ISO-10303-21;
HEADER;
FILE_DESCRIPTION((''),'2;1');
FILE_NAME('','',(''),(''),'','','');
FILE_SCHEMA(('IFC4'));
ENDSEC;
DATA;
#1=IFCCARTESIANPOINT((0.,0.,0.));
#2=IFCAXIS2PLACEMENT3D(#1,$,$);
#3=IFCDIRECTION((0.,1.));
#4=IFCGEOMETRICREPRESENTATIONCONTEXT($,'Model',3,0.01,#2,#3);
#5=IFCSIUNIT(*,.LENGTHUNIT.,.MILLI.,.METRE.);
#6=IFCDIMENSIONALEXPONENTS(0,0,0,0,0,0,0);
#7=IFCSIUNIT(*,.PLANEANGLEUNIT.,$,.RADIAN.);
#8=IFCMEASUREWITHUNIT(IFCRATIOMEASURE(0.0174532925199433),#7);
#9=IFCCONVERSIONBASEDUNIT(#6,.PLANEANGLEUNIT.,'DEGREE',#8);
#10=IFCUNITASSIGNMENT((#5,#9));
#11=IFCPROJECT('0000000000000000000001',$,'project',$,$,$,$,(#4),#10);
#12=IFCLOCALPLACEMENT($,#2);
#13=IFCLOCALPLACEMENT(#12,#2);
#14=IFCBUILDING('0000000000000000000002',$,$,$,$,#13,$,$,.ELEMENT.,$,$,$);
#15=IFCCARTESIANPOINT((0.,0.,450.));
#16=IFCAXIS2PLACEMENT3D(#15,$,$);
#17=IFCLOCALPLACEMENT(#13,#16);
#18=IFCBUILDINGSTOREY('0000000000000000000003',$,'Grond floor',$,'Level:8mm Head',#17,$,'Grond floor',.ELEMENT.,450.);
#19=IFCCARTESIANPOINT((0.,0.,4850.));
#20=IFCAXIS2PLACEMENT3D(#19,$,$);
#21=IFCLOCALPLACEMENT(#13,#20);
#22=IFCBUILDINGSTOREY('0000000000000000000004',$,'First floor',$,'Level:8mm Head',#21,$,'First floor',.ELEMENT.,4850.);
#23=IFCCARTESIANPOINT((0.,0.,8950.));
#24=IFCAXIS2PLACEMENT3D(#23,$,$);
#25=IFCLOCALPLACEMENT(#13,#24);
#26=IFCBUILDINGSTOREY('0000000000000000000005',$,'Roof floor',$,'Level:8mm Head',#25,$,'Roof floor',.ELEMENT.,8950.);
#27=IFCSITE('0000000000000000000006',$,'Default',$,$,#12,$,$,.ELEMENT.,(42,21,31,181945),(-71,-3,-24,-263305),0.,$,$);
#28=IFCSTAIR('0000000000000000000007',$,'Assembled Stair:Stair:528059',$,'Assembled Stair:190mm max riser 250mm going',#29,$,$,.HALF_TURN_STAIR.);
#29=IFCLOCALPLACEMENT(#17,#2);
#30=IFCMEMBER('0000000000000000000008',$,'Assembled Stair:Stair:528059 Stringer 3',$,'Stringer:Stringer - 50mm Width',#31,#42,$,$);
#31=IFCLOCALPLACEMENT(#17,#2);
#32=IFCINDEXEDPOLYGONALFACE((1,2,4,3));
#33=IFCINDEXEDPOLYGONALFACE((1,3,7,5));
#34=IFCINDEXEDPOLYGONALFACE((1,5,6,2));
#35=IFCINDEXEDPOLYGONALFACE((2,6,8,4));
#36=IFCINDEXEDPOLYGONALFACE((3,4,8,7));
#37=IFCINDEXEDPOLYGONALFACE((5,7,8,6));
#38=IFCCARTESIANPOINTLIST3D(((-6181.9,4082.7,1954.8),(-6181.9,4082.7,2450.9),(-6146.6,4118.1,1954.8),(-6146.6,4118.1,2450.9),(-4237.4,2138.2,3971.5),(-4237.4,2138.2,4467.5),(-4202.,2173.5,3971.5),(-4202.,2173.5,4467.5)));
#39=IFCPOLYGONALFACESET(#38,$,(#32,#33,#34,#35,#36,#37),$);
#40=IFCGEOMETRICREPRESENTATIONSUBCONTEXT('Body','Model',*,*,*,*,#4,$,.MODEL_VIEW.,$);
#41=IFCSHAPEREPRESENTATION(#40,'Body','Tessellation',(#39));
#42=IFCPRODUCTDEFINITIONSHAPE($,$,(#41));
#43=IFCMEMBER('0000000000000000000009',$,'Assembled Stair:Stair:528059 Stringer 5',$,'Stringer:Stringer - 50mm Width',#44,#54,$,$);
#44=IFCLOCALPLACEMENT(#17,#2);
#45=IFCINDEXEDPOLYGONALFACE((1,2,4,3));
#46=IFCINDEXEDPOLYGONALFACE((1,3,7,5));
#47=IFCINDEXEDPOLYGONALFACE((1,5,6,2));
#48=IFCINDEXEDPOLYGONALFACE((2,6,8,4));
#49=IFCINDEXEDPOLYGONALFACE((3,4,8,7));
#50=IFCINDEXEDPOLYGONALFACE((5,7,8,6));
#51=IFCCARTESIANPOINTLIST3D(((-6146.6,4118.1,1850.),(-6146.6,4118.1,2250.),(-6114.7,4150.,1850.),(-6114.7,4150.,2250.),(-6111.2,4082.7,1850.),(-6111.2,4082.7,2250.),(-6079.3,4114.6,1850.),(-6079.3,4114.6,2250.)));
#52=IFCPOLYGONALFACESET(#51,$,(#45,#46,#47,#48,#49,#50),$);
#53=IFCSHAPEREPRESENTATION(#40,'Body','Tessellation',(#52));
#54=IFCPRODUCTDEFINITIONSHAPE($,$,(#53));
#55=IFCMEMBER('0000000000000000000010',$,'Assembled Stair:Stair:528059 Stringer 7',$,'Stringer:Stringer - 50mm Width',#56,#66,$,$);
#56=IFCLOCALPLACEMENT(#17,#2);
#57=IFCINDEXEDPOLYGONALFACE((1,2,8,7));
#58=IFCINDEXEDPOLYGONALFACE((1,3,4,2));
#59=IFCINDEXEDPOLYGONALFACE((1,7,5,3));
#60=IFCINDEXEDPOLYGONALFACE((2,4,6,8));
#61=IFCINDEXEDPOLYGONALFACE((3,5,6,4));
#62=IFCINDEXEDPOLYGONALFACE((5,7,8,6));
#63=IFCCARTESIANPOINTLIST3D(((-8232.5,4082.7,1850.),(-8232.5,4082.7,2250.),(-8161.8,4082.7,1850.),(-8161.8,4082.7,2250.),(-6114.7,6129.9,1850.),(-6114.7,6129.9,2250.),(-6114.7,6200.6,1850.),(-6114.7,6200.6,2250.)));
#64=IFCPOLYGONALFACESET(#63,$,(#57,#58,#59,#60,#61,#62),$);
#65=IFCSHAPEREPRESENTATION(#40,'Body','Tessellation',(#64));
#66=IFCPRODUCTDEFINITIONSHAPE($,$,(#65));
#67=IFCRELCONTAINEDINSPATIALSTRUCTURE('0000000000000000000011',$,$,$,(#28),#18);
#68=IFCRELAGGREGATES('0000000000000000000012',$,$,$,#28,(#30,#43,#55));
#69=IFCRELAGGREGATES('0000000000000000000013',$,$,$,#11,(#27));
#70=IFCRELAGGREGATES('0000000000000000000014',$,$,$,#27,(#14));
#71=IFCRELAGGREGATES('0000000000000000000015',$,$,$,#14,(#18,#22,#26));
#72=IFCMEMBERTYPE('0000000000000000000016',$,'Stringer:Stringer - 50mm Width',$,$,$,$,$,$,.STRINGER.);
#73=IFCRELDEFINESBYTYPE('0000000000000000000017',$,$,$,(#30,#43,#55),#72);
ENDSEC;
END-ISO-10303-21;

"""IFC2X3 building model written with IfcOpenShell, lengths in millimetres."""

from ifc_helpers import new_model, entity, si_unit, converted_unit, direction, frame, frame_2d, origin, place, context, subcontext, project, spatial, polyline, rectangle, outline, extrude, type_object, element, aggregate, save


model = new_model("IFC2X3")

# Units and contexts
model_context = context("Model", 3, precision=0.01, world=origin(), true_north=direction((0.0, 1.0)))
body_context = subcontext(model_context, "Body", "Model", "MODEL_VIEW")
ifc_project = project(units=[si_unit("LENGTHUNIT", "METRE", prefix="MILLI"), converted_unit("PLANEANGLEUNIT", "DEGREE", entity("IfcRatioMeasure", 0.0174532925199433), si_unit("PLANEANGLEUNIT", "RADIAN"), dimensions=[0, 0, 0, 0, 0, 0, 0])], contexts=[model_context])

# Site, building, storey
site_placement = place(None, origin())
site = spatial("IfcSite", under=ifc_project, at=site_placement, Name="Default", CompositionType="ELEMENT", RefLatitude=(42, 21, 31, 181945), RefLongitude=(-71, -3, -24, -263305), RefElevation=0.0)
building_placement = place(site_placement, origin())
building = spatial("IfcBuilding", under=site, at=building_placement, CompositionType="ELEMENT")
storey_1_placement = place(building_placement, frame((0.0, 0.0, 450.0)))
storey_1 = spatial("IfcBuildingStorey", under=building, at=storey_1_placement, Name="Grond floor", ObjectType="Level:8mm Head", LongName="Grond floor", CompositionType="ELEMENT", Elevation=450.0)

# Stair, members
stair_1_placement = place(storey_1_placement, origin())
stair_1 = element("IfcStair", 1, at=stair_1_placement, inside=storey_1, Name="Assembled Stair:Stair:528059", ObjectType="Assembled Stair:190mm max riser 250mm going", ShapeType="HALF_TURN_STAIR")
member_type = type_object("IfcMemberType", Name="Stringer:Stringer - 50mm Width", PredefinedType="STRINGER")
member_1_placement = place(stair_1_placement, origin())
member_1 = element("IfcMember", 2, at=member_1_placement, type_object=member_type, Name="Assembled Stair:Stair:528059 Stringer 3", ObjectType="Stringer:Stringer - 50mm Width", context=body_context, shape_type="SweptSolid", body=[
    extrude(outline(polyline([(-1558.4, -200.0), (1851.8, -200.0), (1558.4, 200.0), (-1851.8, 200.0), (-1558.4, -200.0)])), frame((-5209.6, 3110.4, 3211.2), z_axis=(0.707107, 0.707107, 0.0), x_axis=(0.570214, -0.570214, 0.591364)), (0.0, 0.0, 1.0), 50.0),
])
member_2_placement = place(stair_1_placement, origin())
member_2 = element("IfcMember", 3, at=member_2_placement, type_object=member_type, Name="Assembled Stair:Stair:528059 Stringer 5", ObjectType="Stringer:Stringer - 50mm Width", context=body_context, shape_type="SweptSolid", body=[
    extrude(rectangle(XDim=45.1, YDim=50.0, at=frame_2d((0.0, 0.0), x_axis=(1.0, 0.0))), frame((-6112.9, 4116.3, 1850.0), z_axis=(0.0, 0.0, 1.0), x_axis=(0.707107, 0.707107, 0.0)), (0.0, 0.0, 1.0), 400.0),
])
member_3_placement = place(stair_1_placement, origin())
member_3 = element("IfcMember", 4, at=member_3_placement, type_object=member_type, Name="Assembled Stair:Stair:528059 Stringer 7", ObjectType="Stringer:Stringer - 50mm Width", context=body_context, shape_type="SweptSolid", body=[
    extrude(outline(polyline([(-1497.6, -25.0), (1497.6, -25.0), (1447.6, 25.0), (-1447.6, 25.0), (-1497.6, -25.0)])), frame((-7155.9, 5124.0, 1850.0), z_axis=(0.0, 0.0, 1.0), x_axis=(-0.707107, -0.707107, 0.0)), (0.0, 0.0, 1.0), 400.0),
])

# Shared definitions
storey_2_placement = place(building_placement, frame((0.0, 0.0, 4850.0)))
storey_2 = spatial("IfcBuildingStorey", under=building, at=storey_2_placement, Name="First floor", ObjectType="Level:8mm Head", LongName="First floor", CompositionType="ELEMENT", Elevation=4850.0)

# Shared definitions
storey_3_placement = place(building_placement, frame((0.0, 0.0, 8950.0)))
storey_3 = spatial("IfcBuildingStorey", under=building, at=storey_3_placement, Name="Roof floor", ObjectType="Level:8mm Head", LongName="Roof floor", CompositionType="ELEMENT", Elevation=8950.0)

aggregate(stair_1, [member_1, member_2, member_3])

save(model, "model.ifc")
